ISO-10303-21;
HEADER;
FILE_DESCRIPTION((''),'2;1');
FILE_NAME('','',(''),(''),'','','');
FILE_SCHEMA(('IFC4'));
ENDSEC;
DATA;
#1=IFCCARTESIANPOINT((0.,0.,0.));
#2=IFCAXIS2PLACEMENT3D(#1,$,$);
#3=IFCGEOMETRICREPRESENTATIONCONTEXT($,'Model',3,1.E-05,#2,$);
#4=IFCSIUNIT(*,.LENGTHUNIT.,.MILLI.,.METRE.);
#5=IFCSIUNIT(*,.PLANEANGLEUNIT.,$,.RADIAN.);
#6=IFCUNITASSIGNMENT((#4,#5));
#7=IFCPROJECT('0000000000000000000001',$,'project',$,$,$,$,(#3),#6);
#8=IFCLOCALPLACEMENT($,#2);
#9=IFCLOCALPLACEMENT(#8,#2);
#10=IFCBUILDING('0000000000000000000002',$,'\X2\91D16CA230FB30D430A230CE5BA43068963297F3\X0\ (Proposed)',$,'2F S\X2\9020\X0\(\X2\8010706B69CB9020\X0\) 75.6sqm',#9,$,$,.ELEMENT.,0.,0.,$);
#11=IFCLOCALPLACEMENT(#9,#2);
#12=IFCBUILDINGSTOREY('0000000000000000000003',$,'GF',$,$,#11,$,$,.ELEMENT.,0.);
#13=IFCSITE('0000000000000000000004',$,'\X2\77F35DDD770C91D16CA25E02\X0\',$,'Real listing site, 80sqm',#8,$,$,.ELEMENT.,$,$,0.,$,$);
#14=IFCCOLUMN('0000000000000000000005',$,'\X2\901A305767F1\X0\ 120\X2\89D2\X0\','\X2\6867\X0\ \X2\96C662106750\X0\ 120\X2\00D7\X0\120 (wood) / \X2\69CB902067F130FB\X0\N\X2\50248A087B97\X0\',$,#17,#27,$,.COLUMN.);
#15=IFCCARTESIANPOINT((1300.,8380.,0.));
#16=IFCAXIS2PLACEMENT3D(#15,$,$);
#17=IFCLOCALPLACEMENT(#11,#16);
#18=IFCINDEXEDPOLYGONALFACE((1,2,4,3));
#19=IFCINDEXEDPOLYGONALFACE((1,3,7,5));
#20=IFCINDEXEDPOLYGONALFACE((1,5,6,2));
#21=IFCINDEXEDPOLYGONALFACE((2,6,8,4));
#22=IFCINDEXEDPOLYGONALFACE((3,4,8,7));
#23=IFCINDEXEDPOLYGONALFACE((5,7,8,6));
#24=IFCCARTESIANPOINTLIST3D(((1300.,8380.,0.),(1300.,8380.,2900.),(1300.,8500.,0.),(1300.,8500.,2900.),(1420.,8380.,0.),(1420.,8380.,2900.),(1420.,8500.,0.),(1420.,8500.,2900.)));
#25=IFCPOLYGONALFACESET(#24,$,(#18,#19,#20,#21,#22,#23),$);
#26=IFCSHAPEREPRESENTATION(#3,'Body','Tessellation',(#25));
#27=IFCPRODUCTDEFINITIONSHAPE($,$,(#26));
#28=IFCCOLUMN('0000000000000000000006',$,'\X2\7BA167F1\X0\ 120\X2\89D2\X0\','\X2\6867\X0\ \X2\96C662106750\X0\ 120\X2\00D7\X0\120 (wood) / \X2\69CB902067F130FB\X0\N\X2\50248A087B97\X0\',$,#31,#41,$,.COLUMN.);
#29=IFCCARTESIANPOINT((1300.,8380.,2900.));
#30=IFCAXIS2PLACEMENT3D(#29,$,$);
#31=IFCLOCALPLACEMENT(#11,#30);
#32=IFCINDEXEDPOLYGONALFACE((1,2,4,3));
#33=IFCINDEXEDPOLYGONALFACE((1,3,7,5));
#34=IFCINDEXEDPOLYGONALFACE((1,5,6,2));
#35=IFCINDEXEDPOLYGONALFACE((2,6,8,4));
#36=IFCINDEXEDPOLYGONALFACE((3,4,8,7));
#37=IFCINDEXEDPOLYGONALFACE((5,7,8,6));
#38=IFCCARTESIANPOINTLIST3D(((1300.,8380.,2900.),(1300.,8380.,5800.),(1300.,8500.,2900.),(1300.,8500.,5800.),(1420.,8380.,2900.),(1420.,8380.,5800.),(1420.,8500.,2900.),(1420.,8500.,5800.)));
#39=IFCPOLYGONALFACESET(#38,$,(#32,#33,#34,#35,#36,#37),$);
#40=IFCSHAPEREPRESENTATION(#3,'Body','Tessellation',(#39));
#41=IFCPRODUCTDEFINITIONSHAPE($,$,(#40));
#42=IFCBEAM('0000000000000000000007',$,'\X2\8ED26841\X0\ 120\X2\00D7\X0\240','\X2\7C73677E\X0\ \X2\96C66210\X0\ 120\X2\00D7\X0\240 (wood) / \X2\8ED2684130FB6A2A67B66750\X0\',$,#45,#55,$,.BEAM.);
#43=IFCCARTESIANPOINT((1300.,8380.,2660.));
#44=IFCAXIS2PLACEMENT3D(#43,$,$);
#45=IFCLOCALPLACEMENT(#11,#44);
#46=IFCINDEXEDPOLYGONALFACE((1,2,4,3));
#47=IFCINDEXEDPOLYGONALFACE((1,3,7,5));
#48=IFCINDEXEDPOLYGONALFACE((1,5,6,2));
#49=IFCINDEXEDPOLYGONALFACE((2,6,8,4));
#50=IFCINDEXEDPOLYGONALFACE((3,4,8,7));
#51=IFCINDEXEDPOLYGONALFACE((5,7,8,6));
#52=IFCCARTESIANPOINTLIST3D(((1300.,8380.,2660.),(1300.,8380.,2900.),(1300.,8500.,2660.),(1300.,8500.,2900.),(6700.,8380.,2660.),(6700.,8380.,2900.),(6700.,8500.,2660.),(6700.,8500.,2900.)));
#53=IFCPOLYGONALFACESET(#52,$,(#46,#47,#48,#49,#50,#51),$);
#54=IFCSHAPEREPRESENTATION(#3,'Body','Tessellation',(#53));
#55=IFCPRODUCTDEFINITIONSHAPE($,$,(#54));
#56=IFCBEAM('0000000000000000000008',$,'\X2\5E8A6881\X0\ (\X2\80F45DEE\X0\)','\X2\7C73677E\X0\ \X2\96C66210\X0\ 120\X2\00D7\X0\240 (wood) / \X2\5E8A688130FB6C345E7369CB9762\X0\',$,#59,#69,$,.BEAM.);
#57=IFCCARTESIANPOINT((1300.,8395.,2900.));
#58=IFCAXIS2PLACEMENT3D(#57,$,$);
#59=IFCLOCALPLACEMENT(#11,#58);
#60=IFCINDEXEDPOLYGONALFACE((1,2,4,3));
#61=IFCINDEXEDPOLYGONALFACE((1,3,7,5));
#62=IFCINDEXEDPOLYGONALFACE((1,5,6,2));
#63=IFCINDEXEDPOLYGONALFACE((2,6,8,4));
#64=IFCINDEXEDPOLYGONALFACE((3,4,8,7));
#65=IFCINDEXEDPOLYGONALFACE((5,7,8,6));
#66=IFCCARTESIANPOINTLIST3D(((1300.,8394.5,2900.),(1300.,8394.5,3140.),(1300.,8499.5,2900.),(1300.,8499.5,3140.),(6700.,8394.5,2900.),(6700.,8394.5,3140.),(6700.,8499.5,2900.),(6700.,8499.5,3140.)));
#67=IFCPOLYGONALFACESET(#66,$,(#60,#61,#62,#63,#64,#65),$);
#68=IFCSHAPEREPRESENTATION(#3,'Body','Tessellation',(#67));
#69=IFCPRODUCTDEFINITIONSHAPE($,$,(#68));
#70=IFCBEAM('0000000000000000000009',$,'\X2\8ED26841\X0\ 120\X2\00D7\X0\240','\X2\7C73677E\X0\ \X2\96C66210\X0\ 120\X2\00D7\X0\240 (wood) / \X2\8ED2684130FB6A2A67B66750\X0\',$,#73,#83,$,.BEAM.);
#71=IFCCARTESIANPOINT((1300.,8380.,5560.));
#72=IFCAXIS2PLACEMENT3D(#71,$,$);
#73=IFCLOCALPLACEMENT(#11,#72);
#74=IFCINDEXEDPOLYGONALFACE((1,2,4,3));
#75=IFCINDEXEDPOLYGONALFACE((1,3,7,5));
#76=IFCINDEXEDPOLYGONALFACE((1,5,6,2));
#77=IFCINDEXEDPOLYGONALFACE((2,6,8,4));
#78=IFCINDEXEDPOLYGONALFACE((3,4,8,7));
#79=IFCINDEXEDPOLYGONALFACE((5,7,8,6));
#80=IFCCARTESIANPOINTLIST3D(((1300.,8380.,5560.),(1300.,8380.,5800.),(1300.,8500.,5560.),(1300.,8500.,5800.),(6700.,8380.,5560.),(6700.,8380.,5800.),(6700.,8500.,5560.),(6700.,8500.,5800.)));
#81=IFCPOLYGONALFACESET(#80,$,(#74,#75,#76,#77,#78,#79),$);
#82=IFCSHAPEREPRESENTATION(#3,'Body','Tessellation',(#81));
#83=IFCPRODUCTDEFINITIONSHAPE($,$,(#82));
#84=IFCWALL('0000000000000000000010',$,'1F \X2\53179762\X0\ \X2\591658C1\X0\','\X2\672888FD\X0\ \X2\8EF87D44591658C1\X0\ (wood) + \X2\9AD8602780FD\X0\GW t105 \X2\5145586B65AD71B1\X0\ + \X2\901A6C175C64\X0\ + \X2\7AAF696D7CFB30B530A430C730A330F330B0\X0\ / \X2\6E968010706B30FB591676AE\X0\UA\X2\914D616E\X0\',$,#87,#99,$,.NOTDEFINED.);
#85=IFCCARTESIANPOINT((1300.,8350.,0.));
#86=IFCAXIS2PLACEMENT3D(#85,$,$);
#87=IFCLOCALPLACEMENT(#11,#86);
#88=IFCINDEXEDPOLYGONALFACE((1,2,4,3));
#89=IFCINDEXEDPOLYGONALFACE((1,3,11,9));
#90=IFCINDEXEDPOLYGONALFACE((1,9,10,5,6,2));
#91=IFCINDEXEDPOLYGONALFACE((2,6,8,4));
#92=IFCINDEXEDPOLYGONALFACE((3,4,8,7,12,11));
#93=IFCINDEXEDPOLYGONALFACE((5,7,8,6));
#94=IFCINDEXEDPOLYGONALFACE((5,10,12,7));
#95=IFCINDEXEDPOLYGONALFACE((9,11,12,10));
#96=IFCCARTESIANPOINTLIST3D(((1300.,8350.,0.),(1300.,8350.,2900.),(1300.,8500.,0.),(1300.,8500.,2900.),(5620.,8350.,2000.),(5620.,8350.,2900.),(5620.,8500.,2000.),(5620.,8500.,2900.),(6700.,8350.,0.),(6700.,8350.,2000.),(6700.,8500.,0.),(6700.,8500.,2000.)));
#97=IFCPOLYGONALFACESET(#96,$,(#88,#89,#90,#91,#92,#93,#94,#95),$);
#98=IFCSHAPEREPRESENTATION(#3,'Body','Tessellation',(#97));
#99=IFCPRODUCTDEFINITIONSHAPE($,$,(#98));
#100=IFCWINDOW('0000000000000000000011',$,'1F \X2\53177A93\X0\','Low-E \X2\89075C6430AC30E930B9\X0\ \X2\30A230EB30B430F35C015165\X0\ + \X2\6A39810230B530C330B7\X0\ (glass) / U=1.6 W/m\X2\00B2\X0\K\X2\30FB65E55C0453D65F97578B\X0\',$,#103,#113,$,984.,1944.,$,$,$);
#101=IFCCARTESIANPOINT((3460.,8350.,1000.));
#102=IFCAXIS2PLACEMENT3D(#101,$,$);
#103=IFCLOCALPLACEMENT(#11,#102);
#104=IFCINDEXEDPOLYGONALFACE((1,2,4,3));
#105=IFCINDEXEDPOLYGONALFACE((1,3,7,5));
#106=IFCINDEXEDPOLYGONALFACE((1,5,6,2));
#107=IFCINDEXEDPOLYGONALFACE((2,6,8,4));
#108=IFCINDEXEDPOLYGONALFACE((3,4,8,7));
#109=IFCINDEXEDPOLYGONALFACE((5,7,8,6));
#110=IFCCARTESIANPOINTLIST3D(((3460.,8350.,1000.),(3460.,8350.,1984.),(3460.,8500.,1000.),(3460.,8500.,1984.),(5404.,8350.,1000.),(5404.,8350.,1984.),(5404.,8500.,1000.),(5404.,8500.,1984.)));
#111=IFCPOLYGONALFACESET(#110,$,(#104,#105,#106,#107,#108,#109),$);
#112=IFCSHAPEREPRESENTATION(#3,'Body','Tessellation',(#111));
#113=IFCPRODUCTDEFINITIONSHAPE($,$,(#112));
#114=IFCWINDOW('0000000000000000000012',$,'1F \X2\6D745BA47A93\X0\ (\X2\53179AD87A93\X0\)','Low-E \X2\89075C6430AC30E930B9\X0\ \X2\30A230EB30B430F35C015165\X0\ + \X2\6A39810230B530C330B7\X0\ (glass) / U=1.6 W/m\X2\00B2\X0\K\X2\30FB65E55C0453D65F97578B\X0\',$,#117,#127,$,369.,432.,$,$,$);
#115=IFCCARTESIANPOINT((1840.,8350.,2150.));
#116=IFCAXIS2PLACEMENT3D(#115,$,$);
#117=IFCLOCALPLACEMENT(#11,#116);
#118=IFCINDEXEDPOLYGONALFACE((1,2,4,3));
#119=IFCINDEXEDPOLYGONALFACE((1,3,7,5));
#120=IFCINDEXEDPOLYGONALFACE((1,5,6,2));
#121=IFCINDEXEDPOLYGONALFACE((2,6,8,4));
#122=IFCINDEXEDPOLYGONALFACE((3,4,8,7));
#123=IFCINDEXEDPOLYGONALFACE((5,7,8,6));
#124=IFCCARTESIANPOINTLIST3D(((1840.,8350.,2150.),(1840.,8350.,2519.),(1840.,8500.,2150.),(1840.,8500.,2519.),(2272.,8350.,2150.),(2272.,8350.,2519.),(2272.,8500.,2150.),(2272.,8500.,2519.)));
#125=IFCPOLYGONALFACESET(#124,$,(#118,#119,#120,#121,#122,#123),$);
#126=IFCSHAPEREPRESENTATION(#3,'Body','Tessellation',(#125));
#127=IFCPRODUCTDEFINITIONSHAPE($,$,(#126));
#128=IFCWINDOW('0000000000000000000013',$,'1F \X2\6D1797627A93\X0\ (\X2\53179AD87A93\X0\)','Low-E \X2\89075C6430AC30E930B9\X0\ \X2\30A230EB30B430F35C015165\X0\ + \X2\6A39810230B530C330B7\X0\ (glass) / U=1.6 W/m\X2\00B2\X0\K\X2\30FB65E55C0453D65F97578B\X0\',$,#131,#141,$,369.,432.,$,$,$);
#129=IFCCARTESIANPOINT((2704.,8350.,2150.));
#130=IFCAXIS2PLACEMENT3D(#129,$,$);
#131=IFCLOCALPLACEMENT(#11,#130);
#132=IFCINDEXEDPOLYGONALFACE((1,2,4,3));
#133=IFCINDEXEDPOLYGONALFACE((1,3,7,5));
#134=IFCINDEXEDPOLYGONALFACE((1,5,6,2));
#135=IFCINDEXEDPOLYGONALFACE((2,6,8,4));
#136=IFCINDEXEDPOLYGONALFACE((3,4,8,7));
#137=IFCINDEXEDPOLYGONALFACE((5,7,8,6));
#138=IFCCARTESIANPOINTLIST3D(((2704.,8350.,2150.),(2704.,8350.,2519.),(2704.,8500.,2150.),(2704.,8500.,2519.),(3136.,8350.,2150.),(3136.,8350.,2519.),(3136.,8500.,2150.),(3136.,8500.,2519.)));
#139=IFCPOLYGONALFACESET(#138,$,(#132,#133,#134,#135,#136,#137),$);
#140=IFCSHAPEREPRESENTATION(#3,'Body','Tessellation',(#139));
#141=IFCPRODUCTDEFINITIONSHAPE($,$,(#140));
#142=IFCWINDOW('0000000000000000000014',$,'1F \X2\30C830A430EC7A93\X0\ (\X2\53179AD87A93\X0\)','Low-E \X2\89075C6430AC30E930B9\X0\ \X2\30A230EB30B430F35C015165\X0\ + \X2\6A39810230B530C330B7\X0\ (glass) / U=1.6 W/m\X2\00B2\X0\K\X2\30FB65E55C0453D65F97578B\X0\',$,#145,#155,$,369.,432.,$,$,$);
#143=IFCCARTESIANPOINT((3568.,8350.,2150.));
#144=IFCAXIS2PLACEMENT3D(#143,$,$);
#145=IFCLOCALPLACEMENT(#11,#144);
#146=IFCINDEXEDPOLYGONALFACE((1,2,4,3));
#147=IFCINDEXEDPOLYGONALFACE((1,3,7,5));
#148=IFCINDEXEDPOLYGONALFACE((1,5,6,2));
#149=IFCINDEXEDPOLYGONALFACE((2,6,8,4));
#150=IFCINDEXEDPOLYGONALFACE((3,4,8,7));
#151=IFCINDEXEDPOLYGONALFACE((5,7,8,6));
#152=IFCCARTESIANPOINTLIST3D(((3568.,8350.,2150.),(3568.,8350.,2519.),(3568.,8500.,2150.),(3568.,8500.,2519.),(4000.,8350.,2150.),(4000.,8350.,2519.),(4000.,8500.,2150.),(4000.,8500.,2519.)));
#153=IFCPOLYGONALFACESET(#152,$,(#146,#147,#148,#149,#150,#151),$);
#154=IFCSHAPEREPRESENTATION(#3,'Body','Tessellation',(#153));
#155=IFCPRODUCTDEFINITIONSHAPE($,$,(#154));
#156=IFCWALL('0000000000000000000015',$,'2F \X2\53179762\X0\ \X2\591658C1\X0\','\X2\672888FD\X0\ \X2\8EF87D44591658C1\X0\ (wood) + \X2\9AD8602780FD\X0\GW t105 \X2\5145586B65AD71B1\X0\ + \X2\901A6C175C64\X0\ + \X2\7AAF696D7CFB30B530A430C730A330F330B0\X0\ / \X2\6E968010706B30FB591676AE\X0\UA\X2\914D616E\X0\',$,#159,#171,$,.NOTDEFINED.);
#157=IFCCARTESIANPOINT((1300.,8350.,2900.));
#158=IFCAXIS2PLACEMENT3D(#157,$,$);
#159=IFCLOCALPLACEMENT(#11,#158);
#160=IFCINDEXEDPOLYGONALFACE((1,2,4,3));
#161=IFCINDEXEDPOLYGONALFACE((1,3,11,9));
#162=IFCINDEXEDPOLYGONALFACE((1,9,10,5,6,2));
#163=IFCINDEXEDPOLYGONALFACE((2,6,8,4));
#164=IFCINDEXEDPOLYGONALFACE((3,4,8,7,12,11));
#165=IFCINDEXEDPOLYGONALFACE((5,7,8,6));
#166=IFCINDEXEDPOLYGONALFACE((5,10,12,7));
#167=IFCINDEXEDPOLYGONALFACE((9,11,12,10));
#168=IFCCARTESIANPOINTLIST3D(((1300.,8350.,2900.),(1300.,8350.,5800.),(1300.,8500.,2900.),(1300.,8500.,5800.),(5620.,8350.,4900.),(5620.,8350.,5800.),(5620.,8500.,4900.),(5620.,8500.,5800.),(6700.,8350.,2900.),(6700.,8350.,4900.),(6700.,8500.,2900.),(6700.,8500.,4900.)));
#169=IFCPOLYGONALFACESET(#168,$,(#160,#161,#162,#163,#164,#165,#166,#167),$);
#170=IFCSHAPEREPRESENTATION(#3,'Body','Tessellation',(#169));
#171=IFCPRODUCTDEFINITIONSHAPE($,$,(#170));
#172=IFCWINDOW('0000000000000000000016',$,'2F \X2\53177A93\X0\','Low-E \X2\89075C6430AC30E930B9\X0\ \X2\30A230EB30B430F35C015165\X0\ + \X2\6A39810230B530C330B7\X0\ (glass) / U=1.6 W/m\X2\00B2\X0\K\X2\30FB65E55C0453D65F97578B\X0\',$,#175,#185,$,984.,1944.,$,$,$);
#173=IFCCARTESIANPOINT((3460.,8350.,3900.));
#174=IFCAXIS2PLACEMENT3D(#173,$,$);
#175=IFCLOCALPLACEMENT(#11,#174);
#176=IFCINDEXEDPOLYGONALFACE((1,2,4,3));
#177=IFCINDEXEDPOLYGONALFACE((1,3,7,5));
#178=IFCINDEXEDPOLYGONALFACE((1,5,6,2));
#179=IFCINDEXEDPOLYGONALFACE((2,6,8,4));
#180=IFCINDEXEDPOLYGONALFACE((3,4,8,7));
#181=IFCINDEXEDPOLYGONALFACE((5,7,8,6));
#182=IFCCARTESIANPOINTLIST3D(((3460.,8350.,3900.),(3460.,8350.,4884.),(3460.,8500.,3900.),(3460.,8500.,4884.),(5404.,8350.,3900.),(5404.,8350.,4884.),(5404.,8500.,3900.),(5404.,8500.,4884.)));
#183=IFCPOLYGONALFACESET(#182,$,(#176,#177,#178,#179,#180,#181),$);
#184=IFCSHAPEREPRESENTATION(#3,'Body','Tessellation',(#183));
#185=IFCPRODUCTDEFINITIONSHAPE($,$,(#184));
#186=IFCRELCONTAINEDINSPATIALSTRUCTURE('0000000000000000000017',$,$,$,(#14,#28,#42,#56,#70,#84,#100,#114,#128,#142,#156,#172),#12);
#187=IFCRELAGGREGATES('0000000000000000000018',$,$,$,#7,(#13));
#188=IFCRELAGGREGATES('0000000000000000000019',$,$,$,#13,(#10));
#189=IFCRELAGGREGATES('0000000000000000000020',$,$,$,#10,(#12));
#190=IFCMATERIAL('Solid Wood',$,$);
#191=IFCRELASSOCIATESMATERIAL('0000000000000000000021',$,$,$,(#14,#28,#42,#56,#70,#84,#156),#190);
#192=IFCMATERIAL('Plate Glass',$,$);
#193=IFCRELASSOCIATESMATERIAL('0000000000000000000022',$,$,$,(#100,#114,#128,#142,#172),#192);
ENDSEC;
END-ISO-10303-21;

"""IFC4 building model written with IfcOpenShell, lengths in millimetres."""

from ifc_helpers import new_model, si_unit, frame, frame_2d, origin, place, context, project, spatial, rectangle, extrude, material, element, fill, save


model = new_model("IFC4")

# Units and contexts
model_context = context("Model", 3, precision=1e-05, world=origin())
ifc_project = project(units=[si_unit("LENGTHUNIT", "METRE", prefix="MILLI"), si_unit("PLANEANGLEUNIT", "RADIAN")], contexts=[model_context])

# Site, building, storey
site_placement = place(None, origin())
site = spatial("IfcSite", under=ifc_project, at=site_placement, Name="石川県金沢市", ObjectType="Real listing site, 80sqm", CompositionType="ELEMENT", RefElevation=0.0)
building_placement = place(site_placement, origin())
building = spatial("IfcBuilding", under=site, at=building_placement, Name="金沢・ピアノ室と防音 (Proposed)", ObjectType="2F S造(耐火構造) 75.6sqm", CompositionType="ELEMENT", ElevationOfRefHeight=0.0, ElevationOfTerrain=0.0)
storey_placement = place(building_placement, origin())
storey = spatial("IfcBuildingStorey", under=building, at=storey_placement, Name="GF", CompositionType="ELEMENT", Elevation=0.0)

# Columns
ifc_material_1 = material(Name="Solid Wood")
column_1_placement = place(storey_placement, frame((1300.0, 8380.0, 0.0)))
element("IfcColumn", 1, at=column_1_placement, inside=storey, material=ifc_material_1, Name="通し柱 120角", Description="桧 集成材 120×120 (wood) / 構造柱・N値計算", PredefinedType="COLUMN", context=model_context, shape_type="SweptSolid", body=[
    extrude(rectangle(XDim=120.0, YDim=120.0, at=frame_2d((60.0, 60.0))), frame((1300.0, 8380.0, 0.0)), (0.0, 0.0, 1.0), 2900.0),
])
column_2_placement = place(storey_placement, frame((1300.0, 8380.0, 2900.0)))
element("IfcColumn", 2, at=column_2_placement, inside=storey, material=ifc_material_1, Name="管柱 120角", Description="桧 集成材 120×120 (wood) / 構造柱・N値計算", PredefinedType="COLUMN", context=model_context, shape_type="SweptSolid", body=[
    extrude(rectangle(XDim=120.0, YDim=120.0, at=frame_2d((60.0, 60.0))), frame((1300.0, 8380.0, 2900.0)), (0.0, 0.0, 1.0), 2900.0),
])

# Beams
beam_1_placement = place(storey_placement, frame((1300.0, 8380.0, 2660.0)))
element("IfcBeam", 3, at=beam_1_placement, inside=storey, material=ifc_material_1, Name="軒桁 120×240", Description="米松 集成 120×240 (wood) / 軒桁・横架材", PredefinedType="BEAM", context=model_context, shape_type="SweptSolid", body=[
    extrude(rectangle(XDim=5400.0, YDim=120.0, at=frame_2d((2700.0, 60.0))), frame((1300.0, 8380.0, 2660.0)), (0.0, 0.0, 1.0), 240.0),
])
beam_2_placement = place(storey_placement, frame((1300.0, 8395.0, 2900.0)))
element("IfcBeam", 4, at=beam_2_placement, inside=storey, material=ifc_material_1, Name="床梁 (胴差)", Description="米松 集成 120×240 (wood) / 床梁・水平構面", PredefinedType="BEAM", context=model_context, shape_type="SweptSolid", body=[
    extrude(rectangle(XDim=5400.0, YDim=105.0, at=frame_2d((2700.0, 52.0))), frame((1300.0, 8395.0, 2900.0)), (0.0, 0.0, 1.0), 240.0),
])
beam_3_placement = place(storey_placement, frame((1300.0, 8380.0, 5560.0)))
element("IfcBeam", 5, at=beam_3_placement, inside=storey, material=ifc_material_1, Name="軒桁 120×240", Description="米松 集成 120×240 (wood) / 軒桁・横架材", PredefinedType="BEAM", context=model_context, shape_type="SweptSolid", body=[
    extrude(rectangle(XDim=5400.0, YDim=120.0, at=frame_2d((2700.0, 60.0))), frame((1300.0, 8380.0, 5560.0)), (0.0, 0.0, 1.0), 240.0),
])

# Wall, openings, windows
wall_1_placement = place(storey_placement, frame((1300.0, 8350.0, 0.0)))
wall_1 = element("IfcWall", 6, at=wall_1_placement, inside=storey, material=ifc_material_1, Name="1F 北面 外壁", Description="木製 軸組外壁 (wood) + 高性能GW t105 充填断熱 + 通気層 + 窯業系サイディング / 準耐火・外皮UA配慮", PredefinedType="NOTDEFINED", context=model_context, shape_type="SweptSolid", body=[
    extrude(rectangle(XDim=5400.0, YDim=150.0, at=frame_2d((2700.0, 75.0))), frame((1300.0, 8350.0, 0.0)), (0.0, 0.0, 1.0), 2900.0),
])
opening_1_placement = place(storey_placement, frame((3460.0, 8350.0, 1000.0)))
opening_1 = element("IfcOpeningElement", 7, at=opening_1_placement, cuts=wall_1, PredefinedType="NOTDEFINED", context=model_context, shape_type="SweptSolid", body=[
    extrude(rectangle(XDim=1944.0, YDim=150.0, at=frame_2d((972.0, 75.0))), frame((3460.0, 8350.0, 1000.0)), (0.0, 0.0, 1.0), 984.0),
])
opening_2_placement = place(storey_placement, frame((1840.0, 8350.0, 2150.0)))
opening_2 = element("IfcOpeningElement", 8, at=opening_2_placement, cuts=wall_1, PredefinedType="NOTDEFINED", context=model_context, shape_type="SweptSolid", body=[
    extrude(rectangle(XDim=432.0, YDim=150.0, at=frame_2d((216.0, 75.0))), frame((1840.0, 8350.0, 2150.0)), (0.0, 0.0, 1.0), 369.0),
])
opening_3_placement = place(storey_placement, frame((2704.0, 8350.0, 2150.0)))
opening_3 = element("IfcOpeningElement", 9, at=opening_3_placement, cuts=wall_1, PredefinedType="NOTDEFINED", context=model_context, shape_type="SweptSolid", body=[
    extrude(rectangle(XDim=432.0, YDim=150.0, at=frame_2d((216.0, 75.0))), frame((2704.0, 8350.0, 2150.0)), (0.0, 0.0, 1.0), 369.0),
])
opening_4_placement = place(storey_placement, frame((3568.0, 8350.0, 2150.0)))
opening_4 = element("IfcOpeningElement", 10, at=opening_4_placement, cuts=wall_1, PredefinedType="NOTDEFINED", context=model_context, shape_type="SweptSolid", body=[
    extrude(rectangle(XDim=432.0, YDim=150.0, at=frame_2d((216.0, 75.0))), frame((3568.0, 8350.0, 2150.0)), (0.0, 0.0, 1.0), 369.0),
])
ifc_material_2 = material(Name="Plate Glass")
window_1_placement = place(storey_placement, frame((3460.0, 8350.0, 1000.0)))
window_1 = element("IfcWindow", 11, at=window_1_placement, inside=storey, material=ifc_material_2, Name="1F 北窓", Description="Low-E 複層ガラス アルゴン封入 + 樹脂サッシ (glass) / U=1.6 W/m²K・日射取得型", OverallHeight=984.0, OverallWidth=1944.0, context=model_context, shape_type="SweptSolid", body=[
    extrude(rectangle(XDim=1944.0, YDim=150.0, at=frame_2d((972.0, 75.0))), frame((3460.0, 8350.0, 1000.0)), (0.0, 0.0, 1.0), 984.0),
])
fill(opening_1, window_1)
window_2_placement = place(storey_placement, frame((1840.0, 8350.0, 2150.0)))
window_2 = element("IfcWindow", 12, at=window_2_placement, inside=storey, material=ifc_material_2, Name="1F 浴室窓 (北高窓)", Description="Low-E 複層ガラス アルゴン封入 + 樹脂サッシ (glass) / U=1.6 W/m²K・日射取得型", OverallHeight=369.0, OverallWidth=432.0, context=model_context, shape_type="SweptSolid", body=[
    extrude(rectangle(XDim=432.0, YDim=150.0, at=frame_2d((216.0, 75.0))), frame((1840.0, 8350.0, 2150.0)), (0.0, 0.0, 1.0), 369.0),
])
fill(opening_2, window_2)
window_3_placement = place(storey_placement, frame((2704.0, 8350.0, 2150.0)))
window_3 = element("IfcWindow", 13, at=window_3_placement, inside=storey, material=ifc_material_2, Name="1F 洗面窓 (北高窓)", Description="Low-E 複層ガラス アルゴン封入 + 樹脂サッシ (glass) / U=1.6 W/m²K・日射取得型", OverallHeight=369.0, OverallWidth=432.0, context=model_context, shape_type="SweptSolid", body=[
    extrude(rectangle(XDim=432.0, YDim=150.0, at=frame_2d((216.0, 75.0))), frame((2704.0, 8350.0, 2150.0)), (0.0, 0.0, 1.0), 369.0),
])
fill(opening_3, window_3)
window_4_placement = place(storey_placement, frame((3568.0, 8350.0, 2150.0)))
window_4 = element("IfcWindow", 14, at=window_4_placement, inside=storey, material=ifc_material_2, Name="1F トイレ窓 (北高窓)", Description="Low-E 複層ガラス アルゴン封入 + 樹脂サッシ (glass) / U=1.6 W/m²K・日射取得型", OverallHeight=369.0, OverallWidth=432.0, context=model_context, shape_type="SweptSolid", body=[
    extrude(rectangle(XDim=432.0, YDim=150.0, at=frame_2d((216.0, 75.0))), frame((3568.0, 8350.0, 2150.0)), (0.0, 0.0, 1.0), 369.0),
])
fill(opening_4, window_4)

# Wall, opening, window
wall_2_placement = place(storey_placement, frame((1300.0, 8350.0, 2900.0)))
wall_2 = element("IfcWall", 15, at=wall_2_placement, inside=storey, material=ifc_material_1, Name="2F 北面 外壁", Description="木製 軸組外壁 (wood) + 高性能GW t105 充填断熱 + 通気層 + 窯業系サイディング / 準耐火・外皮UA配慮", PredefinedType="NOTDEFINED", context=model_context, shape_type="SweptSolid", body=[
    extrude(rectangle(XDim=5400.0, YDim=150.0, at=frame_2d((2700.0, 75.0))), frame((1300.0, 8350.0, 2900.0)), (0.0, 0.0, 1.0), 2900.0),
])
opening_5_placement = place(storey_placement, frame((3460.0, 8350.0, 3900.0)))
opening_5 = element("IfcOpeningElement", 16, at=opening_5_placement, cuts=wall_2, PredefinedType="NOTDEFINED", context=model_context, shape_type="SweptSolid", body=[
    extrude(rectangle(XDim=1944.0, YDim=150.0, at=frame_2d((972.0, 75.0))), frame((3460.0, 8350.0, 3900.0)), (0.0, 0.0, 1.0), 984.0),
])
window_5_placement = place(storey_placement, frame((3460.0, 8350.0, 3900.0)))
window_5 = element("IfcWindow", 17, at=window_5_placement, inside=storey, material=ifc_material_2, Name="2F 北窓", Description="Low-E 複層ガラス アルゴン封入 + 樹脂サッシ (glass) / U=1.6 W/m²K・日射取得型", OverallHeight=984.0, OverallWidth=1944.0, context=model_context, shape_type="SweptSolid", body=[
    extrude(rectangle(XDim=1944.0, YDim=150.0, at=frame_2d((972.0, 75.0))), frame((3460.0, 8350.0, 3900.0)), (0.0, 0.0, 1.0), 984.0),
])
fill(opening_5, window_5)

save(model, "model.ifc")
